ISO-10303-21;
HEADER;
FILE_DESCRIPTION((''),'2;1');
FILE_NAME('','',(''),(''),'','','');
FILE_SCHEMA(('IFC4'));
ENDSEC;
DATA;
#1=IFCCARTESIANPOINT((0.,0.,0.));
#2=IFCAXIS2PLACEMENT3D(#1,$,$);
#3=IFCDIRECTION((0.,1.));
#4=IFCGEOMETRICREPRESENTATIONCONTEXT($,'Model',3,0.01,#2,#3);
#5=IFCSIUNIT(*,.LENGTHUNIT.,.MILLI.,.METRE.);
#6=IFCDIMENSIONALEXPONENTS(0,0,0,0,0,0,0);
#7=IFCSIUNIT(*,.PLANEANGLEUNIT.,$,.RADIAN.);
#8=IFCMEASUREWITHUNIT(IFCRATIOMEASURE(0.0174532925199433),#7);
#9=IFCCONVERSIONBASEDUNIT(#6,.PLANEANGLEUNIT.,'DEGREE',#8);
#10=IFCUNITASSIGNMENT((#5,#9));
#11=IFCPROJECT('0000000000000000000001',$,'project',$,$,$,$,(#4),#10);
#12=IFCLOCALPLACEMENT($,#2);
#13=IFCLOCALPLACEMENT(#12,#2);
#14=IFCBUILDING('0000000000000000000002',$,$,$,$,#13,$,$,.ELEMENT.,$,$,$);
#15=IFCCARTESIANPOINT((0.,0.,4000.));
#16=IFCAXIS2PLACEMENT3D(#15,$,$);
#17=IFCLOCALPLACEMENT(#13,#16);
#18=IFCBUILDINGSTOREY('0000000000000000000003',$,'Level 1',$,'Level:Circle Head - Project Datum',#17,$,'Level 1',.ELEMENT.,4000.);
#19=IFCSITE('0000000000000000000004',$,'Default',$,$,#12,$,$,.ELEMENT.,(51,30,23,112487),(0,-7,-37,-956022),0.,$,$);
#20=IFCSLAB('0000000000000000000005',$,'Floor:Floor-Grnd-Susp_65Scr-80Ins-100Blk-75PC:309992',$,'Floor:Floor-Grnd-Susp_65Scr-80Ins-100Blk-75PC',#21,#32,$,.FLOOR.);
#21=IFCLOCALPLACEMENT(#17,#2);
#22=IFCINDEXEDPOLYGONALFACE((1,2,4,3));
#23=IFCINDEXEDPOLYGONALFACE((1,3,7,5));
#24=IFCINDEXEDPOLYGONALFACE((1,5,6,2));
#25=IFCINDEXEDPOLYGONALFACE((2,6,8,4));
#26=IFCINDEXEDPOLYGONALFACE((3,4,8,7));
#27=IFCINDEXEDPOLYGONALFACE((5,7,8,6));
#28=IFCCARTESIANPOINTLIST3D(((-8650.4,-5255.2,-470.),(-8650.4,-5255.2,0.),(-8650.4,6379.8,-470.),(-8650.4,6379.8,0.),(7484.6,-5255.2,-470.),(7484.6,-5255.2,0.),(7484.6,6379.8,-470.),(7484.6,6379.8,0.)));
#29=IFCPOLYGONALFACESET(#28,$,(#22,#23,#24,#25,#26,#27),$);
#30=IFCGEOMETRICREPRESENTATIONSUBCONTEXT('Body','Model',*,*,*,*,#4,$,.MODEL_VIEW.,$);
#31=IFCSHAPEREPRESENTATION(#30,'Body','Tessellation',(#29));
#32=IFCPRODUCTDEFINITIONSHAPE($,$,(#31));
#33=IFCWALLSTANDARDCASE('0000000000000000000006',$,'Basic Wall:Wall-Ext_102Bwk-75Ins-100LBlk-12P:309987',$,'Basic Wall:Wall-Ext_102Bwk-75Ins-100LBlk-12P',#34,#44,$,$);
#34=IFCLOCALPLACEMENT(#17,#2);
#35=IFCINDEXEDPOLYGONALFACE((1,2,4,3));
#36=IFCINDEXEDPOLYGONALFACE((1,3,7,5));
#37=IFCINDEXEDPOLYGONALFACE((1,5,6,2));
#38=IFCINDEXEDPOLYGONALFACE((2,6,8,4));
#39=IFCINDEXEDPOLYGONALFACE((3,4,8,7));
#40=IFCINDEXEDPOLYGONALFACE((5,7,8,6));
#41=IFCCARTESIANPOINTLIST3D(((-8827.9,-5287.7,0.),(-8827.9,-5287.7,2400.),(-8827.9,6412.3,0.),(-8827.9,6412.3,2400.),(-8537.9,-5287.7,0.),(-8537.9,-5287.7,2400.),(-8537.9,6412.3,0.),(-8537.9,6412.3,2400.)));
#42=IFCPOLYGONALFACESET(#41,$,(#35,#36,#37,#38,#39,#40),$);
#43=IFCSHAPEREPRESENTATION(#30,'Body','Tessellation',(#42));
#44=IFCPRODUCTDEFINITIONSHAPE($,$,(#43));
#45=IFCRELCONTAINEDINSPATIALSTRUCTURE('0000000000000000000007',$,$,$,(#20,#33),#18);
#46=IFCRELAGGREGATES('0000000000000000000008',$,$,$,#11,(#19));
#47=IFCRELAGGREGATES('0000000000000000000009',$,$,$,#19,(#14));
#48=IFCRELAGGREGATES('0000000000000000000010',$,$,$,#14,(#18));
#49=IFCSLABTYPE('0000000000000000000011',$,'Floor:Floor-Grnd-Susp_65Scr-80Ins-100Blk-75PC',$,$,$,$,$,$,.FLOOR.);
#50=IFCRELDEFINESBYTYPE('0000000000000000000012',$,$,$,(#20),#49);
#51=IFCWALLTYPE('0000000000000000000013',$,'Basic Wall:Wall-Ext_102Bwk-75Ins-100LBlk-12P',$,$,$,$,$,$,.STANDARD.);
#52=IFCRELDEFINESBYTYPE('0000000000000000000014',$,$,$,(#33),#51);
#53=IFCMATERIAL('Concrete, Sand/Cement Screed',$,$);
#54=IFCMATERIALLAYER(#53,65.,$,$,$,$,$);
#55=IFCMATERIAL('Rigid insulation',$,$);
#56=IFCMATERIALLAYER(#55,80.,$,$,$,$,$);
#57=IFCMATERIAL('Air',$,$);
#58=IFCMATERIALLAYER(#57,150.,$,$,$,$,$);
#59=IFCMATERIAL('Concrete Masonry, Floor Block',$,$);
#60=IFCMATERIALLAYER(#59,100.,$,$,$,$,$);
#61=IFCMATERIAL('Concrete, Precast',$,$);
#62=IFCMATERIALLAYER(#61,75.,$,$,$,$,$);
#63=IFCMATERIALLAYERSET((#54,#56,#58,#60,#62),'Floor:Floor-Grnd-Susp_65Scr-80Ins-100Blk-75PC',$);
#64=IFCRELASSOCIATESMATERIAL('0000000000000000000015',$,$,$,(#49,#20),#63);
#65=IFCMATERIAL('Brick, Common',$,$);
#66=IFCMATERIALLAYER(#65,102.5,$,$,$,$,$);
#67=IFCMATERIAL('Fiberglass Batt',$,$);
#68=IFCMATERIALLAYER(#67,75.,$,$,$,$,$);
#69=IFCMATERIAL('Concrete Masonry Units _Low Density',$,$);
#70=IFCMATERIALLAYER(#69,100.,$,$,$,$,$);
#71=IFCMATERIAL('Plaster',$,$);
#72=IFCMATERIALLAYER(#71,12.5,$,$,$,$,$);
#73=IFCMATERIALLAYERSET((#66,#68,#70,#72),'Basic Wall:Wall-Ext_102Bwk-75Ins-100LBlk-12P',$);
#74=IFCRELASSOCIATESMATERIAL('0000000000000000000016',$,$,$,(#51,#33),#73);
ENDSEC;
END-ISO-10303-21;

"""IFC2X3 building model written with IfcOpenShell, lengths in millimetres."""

from ifc_helpers import new_model, entity, si_unit, converted_unit, direction, frame, frame_2d, origin, place, context, subcontext, project, spatial, rectangle, extrude, material, layer, layer_set, layer_usage, type_object, element, save


model = new_model("IFC2X3")

# Units and contexts
model_context = context("Model", 3, precision=0.01, world=origin(), true_north=direction((0.0, 1.0)))
body_context = subcontext(model_context, "Body", "Model", "MODEL_VIEW")
ifc_project = project(units=[si_unit("LENGTHUNIT", "METRE", prefix="MILLI"), converted_unit("PLANEANGLEUNIT", "DEGREE", entity("IfcRatioMeasure", 0.0174532925199433), si_unit("PLANEANGLEUNIT", "RADIAN"), dimensions=[0, 0, 0, 0, 0, 0, 0])], contexts=[model_context])

# Site, building, storey
site_placement = place(None, origin())
site = spatial("IfcSite", under=ifc_project, at=site_placement, Name="Default", CompositionType="ELEMENT", RefLatitude=(51, 30, 23, 112487), RefLongitude=(0, -7, -37, -956022), RefElevation=0.0)
building_placement = place(site_placement, origin())
building = spatial("IfcBuilding", under=site, at=building_placement, CompositionType="ELEMENT")
storey_placement = place(building_placement, frame((0.0, 0.0, 4000.0)))
storey = spatial("IfcBuildingStorey", under=building, at=storey_placement, Name="Level 1", ObjectType="Level:Circle Head - Project Datum", LongName="Level 1", CompositionType="ELEMENT", Elevation=4000.0)

# Slab
ifc_material_1 = material(Name="Concrete, Sand/Cement Screed")
ifc_layer_1 = layer(ifc_material_1, 65.0)
ifc_material_2 = material(Name="Rigid insulation")
ifc_layer_2 = layer(ifc_material_2, 80.0)
ifc_material_3 = material(Name="Air")
ifc_layer_3 = layer(ifc_material_3, 150.0)
ifc_material_4 = material(Name="Concrete Masonry, Floor Block")
ifc_layer_4 = layer(ifc_material_4, 100.0)
ifc_material_5 = material(Name="Concrete, Precast")
ifc_layer_5 = layer(ifc_material_5, 75.0)
ifc_layer_set_1 = layer_set([ifc_layer_1, ifc_layer_2, ifc_layer_3, ifc_layer_4, ifc_layer_5], Name="Floor:Floor-Grnd-Susp_65Scr-80Ins-100Blk-75PC")
ifc_layer_usage_1 = layer_usage(ifc_layer_set_1, "AXIS3", "POSITIVE", 0.0)
slab_type = type_object("IfcSlabType", Name="Floor:Floor-Grnd-Susp_65Scr-80Ins-100Blk-75PC", PredefinedType="FLOOR", material=ifc_layer_set_1)
slab_placement = place(storey_placement, origin())
element("IfcSlab", 1, at=slab_placement, inside=storey, type_object=slab_type, material=ifc_layer_usage_1, Name="Floor:Floor-Grnd-Susp_65Scr-80Ins-100Blk-75PC:309992", ObjectType="Floor:Floor-Grnd-Susp_65Scr-80Ins-100Blk-75PC", PredefinedType="FLOOR", context=body_context, shape_type="SweptSolid", body=[
    extrude(rectangle(XDim=11635.0, YDim=16135.0, at=frame_2d((0.0, 0.0), x_axis=(1.0, 0.0))), frame((-582.9, 562.3, 0.0), z_axis=(0.0, 0.0, -1.0), x_axis=(0.0, 1.0, 0.0)), (0.0, 0.0, 1.0), 470.0),
])

# Wall
ifc_material_6 = material(Name="Brick, Common")
ifc_layer_6 = layer(ifc_material_6, 102.5)
ifc_material_7 = material(Name="Fiberglass Batt")
ifc_layer_7 = layer(ifc_material_7, 75.0)
ifc_material_8 = material(Name="Concrete Masonry Units _Low Density")
ifc_layer_8 = layer(ifc_material_8, 100.0)
ifc_material_9 = material(Name="Plaster")
ifc_layer_9 = layer(ifc_material_9, 12.5)
ifc_layer_set_2 = layer_set([ifc_layer_6, ifc_layer_7, ifc_layer_8, ifc_layer_9], Name="Basic Wall:Wall-Ext_102Bwk-75Ins-100LBlk-12P")
ifc_layer_usage_2 = layer_usage(ifc_layer_set_2, "AXIS2", "NEGATIVE", 145.0)
wall_type = type_object("IfcWallType", Name="Basic Wall:Wall-Ext_102Bwk-75Ins-100LBlk-12P", PredefinedType="STANDARD", material=ifc_layer_set_2)
wall_placement = place(storey_placement, frame((-8682.9, -5287.7, 0.0), z_axis=(0.0, 0.0, 1.0), x_axis=(0.0, 1.0, 0.0)))
element("IfcWallStandardCase", 2, at=wall_placement, inside=storey, type_object=wall_type, material=ifc_layer_usage_2, Name="Basic Wall:Wall-Ext_102Bwk-75Ins-100LBlk-12P:309987", ObjectType="Basic Wall:Wall-Ext_102Bwk-75Ins-100LBlk-12P", context=body_context, shape_type="SweptSolid", body=[
    extrude(rectangle(XDim=11700.0, YDim=290.0, at=frame_2d((5850.0, 0.0), x_axis=(-1.0, 0.0))), origin(), (0.0, 0.0, 1.0), 2400.0),
])

save(model, "model.ifc")
